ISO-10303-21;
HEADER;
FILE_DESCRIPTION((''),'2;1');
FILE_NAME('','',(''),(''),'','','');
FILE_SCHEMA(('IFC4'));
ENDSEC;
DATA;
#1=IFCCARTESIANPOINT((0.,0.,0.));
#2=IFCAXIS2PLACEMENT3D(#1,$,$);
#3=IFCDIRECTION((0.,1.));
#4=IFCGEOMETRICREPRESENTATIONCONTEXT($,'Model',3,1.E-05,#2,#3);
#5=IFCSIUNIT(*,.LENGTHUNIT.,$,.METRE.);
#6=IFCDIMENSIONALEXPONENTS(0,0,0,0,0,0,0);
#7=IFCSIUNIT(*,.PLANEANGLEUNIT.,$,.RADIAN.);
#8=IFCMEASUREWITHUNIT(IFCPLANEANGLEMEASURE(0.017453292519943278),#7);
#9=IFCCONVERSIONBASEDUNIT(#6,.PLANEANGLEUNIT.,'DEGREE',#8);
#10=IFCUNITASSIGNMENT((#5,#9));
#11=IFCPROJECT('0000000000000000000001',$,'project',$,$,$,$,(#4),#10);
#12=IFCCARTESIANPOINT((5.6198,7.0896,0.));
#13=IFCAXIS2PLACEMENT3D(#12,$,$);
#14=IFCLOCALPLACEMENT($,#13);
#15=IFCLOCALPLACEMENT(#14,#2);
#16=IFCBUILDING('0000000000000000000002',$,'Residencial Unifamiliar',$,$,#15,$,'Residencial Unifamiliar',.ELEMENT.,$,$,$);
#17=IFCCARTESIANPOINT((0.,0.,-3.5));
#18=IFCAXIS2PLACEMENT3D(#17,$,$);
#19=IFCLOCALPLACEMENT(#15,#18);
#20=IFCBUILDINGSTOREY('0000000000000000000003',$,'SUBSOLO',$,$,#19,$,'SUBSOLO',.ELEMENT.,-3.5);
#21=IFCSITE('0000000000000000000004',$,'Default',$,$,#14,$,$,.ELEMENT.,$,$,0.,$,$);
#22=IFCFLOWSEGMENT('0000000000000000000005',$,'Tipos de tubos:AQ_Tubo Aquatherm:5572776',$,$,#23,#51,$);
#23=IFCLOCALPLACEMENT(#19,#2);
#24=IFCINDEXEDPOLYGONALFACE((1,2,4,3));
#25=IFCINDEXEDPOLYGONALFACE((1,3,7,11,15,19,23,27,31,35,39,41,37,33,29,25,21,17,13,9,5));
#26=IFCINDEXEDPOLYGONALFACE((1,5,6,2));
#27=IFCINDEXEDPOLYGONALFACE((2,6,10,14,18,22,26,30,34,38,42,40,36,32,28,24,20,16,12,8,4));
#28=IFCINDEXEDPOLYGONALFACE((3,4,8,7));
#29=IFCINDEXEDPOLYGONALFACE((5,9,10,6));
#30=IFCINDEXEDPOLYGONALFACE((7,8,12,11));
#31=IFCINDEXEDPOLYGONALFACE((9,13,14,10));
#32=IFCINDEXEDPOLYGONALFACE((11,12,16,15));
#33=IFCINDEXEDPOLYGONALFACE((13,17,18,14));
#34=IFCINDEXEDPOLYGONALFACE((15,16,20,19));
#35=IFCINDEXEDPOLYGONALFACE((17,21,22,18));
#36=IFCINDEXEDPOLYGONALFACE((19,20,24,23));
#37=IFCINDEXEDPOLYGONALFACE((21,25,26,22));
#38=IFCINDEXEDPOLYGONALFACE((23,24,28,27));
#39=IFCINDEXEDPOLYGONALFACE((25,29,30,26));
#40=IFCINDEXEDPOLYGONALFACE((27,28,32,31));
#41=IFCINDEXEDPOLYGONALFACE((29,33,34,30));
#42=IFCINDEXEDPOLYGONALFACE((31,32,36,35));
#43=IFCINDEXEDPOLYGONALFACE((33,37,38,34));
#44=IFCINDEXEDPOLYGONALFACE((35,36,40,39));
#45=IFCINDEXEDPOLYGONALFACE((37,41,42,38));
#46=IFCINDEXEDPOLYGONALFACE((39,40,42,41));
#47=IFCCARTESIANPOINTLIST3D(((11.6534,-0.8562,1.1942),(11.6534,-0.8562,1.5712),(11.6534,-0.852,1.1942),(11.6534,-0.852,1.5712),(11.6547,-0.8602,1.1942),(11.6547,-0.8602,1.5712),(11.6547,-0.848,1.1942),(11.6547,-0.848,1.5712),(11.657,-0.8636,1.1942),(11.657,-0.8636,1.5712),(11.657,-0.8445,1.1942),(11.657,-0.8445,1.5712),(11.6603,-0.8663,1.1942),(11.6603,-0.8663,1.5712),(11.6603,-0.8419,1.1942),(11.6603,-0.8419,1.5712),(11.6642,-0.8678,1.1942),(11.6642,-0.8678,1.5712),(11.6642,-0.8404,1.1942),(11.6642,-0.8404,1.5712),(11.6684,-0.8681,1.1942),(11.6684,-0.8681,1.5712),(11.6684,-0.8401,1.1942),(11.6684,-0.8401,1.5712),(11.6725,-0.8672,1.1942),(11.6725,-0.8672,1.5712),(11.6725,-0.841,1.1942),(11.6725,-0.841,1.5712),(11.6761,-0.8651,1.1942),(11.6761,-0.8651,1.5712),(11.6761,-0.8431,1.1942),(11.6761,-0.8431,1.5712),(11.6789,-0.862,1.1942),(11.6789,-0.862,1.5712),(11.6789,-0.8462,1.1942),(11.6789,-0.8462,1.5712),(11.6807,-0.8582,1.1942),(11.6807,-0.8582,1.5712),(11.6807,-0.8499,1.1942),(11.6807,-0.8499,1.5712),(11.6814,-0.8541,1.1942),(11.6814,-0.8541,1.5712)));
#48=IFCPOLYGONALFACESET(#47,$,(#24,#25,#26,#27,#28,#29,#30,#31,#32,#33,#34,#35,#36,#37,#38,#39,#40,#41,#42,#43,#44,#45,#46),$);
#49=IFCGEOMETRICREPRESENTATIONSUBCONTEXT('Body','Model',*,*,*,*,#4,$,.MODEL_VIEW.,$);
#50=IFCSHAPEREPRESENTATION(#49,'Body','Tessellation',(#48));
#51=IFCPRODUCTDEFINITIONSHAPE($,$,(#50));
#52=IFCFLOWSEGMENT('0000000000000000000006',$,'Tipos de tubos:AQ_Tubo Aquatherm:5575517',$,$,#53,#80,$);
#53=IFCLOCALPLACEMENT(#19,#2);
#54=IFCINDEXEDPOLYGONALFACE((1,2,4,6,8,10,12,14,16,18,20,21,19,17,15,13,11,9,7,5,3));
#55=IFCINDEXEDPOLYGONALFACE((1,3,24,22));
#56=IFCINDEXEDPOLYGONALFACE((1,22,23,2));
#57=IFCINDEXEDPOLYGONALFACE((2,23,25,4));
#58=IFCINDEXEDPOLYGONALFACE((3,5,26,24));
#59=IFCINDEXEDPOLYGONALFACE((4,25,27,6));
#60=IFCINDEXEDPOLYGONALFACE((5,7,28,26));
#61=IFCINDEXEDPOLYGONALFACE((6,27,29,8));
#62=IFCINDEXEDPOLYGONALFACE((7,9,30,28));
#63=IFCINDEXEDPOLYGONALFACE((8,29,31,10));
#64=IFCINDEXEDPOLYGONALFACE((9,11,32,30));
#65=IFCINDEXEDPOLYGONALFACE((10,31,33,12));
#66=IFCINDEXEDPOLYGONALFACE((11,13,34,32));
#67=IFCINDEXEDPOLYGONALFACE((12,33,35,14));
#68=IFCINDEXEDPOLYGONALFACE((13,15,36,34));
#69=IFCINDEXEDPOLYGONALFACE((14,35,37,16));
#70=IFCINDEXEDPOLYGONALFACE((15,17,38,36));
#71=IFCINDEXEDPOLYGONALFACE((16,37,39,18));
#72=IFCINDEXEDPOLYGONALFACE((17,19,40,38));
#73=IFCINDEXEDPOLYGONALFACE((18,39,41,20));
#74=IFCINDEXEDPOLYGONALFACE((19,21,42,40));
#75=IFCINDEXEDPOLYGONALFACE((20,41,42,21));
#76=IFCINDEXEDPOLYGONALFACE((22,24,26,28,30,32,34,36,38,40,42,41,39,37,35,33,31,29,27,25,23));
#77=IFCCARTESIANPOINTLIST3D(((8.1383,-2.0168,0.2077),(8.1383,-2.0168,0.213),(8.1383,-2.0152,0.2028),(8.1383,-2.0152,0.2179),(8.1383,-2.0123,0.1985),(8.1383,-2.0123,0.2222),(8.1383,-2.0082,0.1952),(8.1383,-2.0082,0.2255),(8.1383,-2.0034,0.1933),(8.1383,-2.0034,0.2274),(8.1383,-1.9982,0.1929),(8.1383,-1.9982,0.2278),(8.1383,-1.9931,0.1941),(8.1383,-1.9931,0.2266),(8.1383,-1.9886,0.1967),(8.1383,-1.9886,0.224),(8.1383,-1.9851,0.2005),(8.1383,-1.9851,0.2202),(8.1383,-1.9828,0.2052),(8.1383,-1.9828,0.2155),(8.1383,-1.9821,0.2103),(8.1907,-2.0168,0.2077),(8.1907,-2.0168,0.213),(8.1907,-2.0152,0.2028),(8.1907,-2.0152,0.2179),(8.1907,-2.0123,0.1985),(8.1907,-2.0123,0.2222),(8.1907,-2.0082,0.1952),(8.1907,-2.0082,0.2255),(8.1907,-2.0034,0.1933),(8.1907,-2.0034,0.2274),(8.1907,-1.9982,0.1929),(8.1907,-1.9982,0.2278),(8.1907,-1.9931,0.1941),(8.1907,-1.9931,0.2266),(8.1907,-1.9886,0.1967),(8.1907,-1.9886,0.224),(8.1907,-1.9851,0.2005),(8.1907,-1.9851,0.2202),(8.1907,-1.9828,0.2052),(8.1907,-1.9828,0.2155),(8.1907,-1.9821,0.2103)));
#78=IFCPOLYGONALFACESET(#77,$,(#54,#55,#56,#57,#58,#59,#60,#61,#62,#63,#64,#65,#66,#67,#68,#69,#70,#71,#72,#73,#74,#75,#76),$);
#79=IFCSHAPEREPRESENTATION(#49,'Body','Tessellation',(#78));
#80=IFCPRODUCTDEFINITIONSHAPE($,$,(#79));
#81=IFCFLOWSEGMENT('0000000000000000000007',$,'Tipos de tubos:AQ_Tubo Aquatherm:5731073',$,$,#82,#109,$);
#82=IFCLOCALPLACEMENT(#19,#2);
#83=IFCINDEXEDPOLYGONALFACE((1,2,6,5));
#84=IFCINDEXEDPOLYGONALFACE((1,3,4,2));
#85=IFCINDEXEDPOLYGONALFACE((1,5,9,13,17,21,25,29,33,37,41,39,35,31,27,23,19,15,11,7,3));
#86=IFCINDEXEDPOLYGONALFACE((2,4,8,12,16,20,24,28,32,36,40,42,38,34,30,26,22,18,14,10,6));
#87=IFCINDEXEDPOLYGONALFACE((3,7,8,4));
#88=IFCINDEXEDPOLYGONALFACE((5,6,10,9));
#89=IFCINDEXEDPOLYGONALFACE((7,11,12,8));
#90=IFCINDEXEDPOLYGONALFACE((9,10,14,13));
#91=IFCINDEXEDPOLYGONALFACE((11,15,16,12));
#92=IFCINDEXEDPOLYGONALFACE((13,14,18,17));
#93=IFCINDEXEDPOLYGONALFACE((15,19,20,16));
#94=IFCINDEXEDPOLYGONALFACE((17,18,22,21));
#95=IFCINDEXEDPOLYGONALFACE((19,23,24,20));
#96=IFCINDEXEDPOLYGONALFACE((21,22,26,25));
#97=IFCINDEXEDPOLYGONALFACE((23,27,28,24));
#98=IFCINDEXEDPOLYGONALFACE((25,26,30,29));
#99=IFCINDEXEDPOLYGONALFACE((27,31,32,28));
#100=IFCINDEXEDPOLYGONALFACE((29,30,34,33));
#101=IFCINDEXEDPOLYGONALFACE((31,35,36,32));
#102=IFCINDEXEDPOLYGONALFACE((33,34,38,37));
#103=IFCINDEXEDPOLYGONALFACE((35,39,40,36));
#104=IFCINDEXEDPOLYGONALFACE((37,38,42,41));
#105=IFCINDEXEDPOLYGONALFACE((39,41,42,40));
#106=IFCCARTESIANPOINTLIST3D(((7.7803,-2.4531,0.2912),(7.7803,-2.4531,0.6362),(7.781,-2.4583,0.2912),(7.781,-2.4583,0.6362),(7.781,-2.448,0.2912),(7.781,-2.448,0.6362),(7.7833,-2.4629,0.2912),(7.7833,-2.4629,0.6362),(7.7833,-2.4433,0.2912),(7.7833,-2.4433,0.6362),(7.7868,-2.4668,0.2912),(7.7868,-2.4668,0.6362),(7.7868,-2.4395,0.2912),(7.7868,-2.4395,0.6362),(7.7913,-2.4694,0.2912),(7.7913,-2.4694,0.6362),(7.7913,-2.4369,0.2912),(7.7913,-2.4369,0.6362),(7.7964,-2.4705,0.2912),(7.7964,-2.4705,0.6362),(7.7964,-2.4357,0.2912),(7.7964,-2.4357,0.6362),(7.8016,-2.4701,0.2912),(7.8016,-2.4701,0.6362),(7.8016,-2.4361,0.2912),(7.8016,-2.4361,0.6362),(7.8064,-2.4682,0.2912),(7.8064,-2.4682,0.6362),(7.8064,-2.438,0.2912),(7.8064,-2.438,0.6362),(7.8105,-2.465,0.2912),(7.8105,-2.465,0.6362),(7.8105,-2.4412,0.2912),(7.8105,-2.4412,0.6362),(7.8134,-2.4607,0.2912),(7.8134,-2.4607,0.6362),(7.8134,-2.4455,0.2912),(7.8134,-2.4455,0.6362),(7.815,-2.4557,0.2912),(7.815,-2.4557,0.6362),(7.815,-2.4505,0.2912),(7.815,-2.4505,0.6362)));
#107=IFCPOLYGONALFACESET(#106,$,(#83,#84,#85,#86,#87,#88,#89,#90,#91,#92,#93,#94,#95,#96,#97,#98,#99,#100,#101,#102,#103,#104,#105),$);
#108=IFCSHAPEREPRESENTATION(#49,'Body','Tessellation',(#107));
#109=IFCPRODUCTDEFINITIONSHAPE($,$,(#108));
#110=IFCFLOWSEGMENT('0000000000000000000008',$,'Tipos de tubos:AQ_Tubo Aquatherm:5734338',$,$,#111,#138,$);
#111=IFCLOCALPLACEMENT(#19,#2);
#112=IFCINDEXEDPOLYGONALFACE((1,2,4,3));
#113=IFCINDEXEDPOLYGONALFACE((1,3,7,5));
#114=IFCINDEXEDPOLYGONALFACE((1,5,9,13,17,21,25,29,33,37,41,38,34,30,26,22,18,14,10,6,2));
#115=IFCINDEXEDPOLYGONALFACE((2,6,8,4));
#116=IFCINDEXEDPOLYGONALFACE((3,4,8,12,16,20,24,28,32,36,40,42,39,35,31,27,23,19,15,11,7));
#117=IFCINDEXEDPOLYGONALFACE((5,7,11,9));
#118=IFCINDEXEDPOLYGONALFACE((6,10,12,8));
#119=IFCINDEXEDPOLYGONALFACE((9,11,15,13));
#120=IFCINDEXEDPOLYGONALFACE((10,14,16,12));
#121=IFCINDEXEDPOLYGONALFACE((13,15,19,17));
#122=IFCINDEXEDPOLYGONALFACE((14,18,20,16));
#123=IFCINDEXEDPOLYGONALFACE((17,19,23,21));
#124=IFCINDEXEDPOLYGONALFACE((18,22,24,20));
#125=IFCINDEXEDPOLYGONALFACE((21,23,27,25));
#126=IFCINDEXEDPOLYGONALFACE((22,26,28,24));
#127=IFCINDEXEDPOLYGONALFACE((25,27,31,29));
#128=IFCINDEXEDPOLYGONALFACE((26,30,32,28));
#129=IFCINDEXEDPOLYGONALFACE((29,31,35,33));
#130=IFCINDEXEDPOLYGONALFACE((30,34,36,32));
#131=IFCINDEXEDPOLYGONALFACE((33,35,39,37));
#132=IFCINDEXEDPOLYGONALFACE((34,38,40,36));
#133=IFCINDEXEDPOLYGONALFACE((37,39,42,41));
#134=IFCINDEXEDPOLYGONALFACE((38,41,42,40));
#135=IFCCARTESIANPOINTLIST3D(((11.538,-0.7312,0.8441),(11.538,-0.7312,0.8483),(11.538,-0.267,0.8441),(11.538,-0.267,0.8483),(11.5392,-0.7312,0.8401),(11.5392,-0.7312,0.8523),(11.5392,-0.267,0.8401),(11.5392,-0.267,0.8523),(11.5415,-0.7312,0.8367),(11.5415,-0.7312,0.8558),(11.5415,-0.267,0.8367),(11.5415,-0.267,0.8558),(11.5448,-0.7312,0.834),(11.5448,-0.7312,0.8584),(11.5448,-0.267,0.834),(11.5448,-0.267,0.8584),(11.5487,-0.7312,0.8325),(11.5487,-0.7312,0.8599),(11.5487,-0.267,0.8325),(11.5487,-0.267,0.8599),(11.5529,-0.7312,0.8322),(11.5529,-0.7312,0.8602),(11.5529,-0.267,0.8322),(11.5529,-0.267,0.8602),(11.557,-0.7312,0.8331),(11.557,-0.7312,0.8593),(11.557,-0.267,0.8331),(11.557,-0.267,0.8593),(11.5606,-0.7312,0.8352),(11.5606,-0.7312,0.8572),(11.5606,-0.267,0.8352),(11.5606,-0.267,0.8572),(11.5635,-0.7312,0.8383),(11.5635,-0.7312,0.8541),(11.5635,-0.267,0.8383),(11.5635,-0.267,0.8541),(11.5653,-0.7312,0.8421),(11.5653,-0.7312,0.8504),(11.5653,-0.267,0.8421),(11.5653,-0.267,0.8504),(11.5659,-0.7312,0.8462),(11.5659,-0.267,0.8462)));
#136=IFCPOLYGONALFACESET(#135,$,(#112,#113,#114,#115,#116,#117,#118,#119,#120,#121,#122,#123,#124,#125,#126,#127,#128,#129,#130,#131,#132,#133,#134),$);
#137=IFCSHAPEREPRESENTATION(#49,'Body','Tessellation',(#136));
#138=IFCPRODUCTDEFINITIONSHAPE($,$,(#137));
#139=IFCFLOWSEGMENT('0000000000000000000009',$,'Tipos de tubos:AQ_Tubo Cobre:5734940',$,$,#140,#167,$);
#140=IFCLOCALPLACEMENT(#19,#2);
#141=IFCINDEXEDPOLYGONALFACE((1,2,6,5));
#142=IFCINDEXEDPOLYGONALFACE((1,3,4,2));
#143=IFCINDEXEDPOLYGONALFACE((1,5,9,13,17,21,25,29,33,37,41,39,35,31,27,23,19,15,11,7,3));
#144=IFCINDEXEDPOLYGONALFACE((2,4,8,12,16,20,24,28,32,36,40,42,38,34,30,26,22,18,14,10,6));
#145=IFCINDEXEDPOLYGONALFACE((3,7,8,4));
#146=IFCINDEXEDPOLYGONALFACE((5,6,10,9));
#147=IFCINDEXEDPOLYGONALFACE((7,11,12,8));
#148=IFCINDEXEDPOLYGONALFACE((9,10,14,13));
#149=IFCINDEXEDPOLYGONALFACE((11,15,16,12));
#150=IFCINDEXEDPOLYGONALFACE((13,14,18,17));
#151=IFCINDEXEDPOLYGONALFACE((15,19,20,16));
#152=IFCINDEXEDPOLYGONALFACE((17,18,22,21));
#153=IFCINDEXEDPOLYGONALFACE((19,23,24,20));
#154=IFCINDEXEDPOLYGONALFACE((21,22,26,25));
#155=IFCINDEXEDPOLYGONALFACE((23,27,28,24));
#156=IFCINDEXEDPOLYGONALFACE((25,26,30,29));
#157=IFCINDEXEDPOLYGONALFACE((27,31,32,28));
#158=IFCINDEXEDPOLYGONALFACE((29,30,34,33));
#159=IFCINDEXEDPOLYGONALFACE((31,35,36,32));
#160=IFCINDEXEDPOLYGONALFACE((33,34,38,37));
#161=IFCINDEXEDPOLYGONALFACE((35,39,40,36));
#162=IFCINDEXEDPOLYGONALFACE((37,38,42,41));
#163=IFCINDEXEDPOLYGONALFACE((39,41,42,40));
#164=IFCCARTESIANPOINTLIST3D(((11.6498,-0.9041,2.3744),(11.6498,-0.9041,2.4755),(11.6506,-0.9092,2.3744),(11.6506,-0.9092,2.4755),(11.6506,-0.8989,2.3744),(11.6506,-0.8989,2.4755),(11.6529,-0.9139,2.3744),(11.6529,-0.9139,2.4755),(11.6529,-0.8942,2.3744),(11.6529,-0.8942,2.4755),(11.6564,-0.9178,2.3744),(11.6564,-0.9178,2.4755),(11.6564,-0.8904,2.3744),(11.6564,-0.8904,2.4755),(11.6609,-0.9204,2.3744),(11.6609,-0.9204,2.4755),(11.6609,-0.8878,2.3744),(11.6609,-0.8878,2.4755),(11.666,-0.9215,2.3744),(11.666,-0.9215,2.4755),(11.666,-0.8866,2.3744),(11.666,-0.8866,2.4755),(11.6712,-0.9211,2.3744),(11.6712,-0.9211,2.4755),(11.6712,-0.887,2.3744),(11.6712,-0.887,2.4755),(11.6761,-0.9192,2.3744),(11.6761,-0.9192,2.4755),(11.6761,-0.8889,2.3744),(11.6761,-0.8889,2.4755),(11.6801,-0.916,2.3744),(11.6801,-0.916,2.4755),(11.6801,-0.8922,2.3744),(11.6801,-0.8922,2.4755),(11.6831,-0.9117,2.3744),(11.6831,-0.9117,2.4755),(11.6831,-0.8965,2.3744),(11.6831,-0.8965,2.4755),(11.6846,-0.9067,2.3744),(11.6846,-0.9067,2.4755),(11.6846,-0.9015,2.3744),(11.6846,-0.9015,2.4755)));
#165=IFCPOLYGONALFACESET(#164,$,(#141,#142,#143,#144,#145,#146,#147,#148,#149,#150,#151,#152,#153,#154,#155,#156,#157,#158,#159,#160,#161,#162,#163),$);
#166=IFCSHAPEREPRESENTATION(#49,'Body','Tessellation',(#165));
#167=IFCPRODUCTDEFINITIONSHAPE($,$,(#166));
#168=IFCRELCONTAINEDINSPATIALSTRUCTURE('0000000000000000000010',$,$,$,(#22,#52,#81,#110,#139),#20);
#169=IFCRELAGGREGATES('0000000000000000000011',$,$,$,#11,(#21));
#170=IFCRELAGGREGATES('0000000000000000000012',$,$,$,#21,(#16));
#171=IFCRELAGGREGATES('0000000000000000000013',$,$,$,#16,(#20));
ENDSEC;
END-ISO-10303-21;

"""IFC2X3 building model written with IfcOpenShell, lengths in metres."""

from ifc_helpers import new_model, entity, si_unit, converted_unit, direction, frame, origin, origin_2d_with_axis, place, context, subcontext, project, spatial, circle, extrude, element, save


model = new_model("IFC2X3")

# Units and contexts
model_context = context("Model", 3, precision=1e-05, world=origin(), true_north=direction((0.0, 1.0)))
body_context = subcontext(model_context, "Body", "Model", "MODEL_VIEW")
ifc_project = project(units=[si_unit("LENGTHUNIT", "METRE"), converted_unit("PLANEANGLEUNIT", "DEGREE", entity("IfcPlaneAngleMeasure", 0.017453292519943278), si_unit("PLANEANGLEUNIT", "RADIAN"), dimensions=[0, 0, 0, 0, 0, 0, 0])], contexts=[model_context])

# Site, building, storey
site_placement = place(None, frame((5.6198, 7.0896, 0.0)))
site = spatial("IfcSite", under=ifc_project, at=site_placement, Name="Default", CompositionType="ELEMENT", RefElevation=0.0)
building_placement = place(site_placement, origin())
building = spatial("IfcBuilding", under=site, at=building_placement, Name="Residencial Unifamiliar", LongName="Residencial Unifamiliar", CompositionType="ELEMENT")
storey_placement = place(building_placement, frame((0.0, 0.0, -3.5)))
storey = spatial("IfcBuildingStorey", under=building, at=storey_placement, Name="SUBSOLO", LongName="SUBSOLO", CompositionType="ELEMENT", Elevation=-3.5)

# Flow segments
flow_segment_1_placement = place(storey_placement, origin())
element("IfcFlowSegment", 1, at=flow_segment_1_placement, inside=storey, Name="Tipos de tubos:AQ_Tubo Aquatherm:5572776", context=body_context, shape_type="SweptSolid", body=[
    extrude(circle(Radius=0.0141, at=origin_2d_with_axis()), frame((11.6673, -0.8541, 1.1942)), (0.0, 0.0, 1.0), 0.3769),
])
flow_segment_2_placement = place(storey_placement, origin())
element("IfcFlowSegment", 2, at=flow_segment_2_placement, inside=storey, Name="Tipos de tubos:AQ_Tubo Aquatherm:5575517", context=body_context, shape_type="SweptSolid", body=[
    extrude(circle(Radius=0.0175, at=origin_2d_with_axis()), frame((8.1383, -1.9995, 0.2103), z_axis=(1.0, 0.0, 0.0), x_axis=(0.0, 1.0, 0.0)), (0.0, 0.0, 1.0), 0.0524),
])
flow_segment_3_placement = place(storey_placement, origin())
element("IfcFlowSegment", 3, at=flow_segment_3_placement, inside=storey, Name="Tipos de tubos:AQ_Tubo Aquatherm:5731073", context=body_context, shape_type="SweptSolid", body=[
    extrude(circle(Radius=0.0175, at=origin_2d_with_axis()), frame((7.7977, -2.4531, 0.2912), z_axis=(0.0, 0.0, 1.0), x_axis=(-1.0, 0.0, 0.0)), (0.0, 0.0, 1.0), 0.345),
])
flow_segment_4_placement = place(storey_placement, origin())
element("IfcFlowSegment", 4, at=flow_segment_4_placement, inside=storey, Name="Tipos de tubos:AQ_Tubo Aquatherm:5734338", context=body_context, shape_type="SweptSolid", body=[
    extrude(circle(Radius=0.0141, at=origin_2d_with_axis()), frame((11.5518, -0.7312, 0.8462), z_axis=(0.0, 1.0, 0.0), x_axis=(1.0, 0.0, 0.0)), (0.0, 0.0, 1.0), 0.4642),
])
flow_segment_5_placement = place(storey_placement, origin())
element("IfcFlowSegment", 5, at=flow_segment_5_placement, inside=storey, Name="Tipos de tubos:AQ_Tubo Cobre:5734940", context=body_context, shape_type="SweptSolid", body=[
    extrude(circle(Radius=0.0175, at=origin_2d_with_axis()), frame((11.6673, -0.9041, 2.3744), z_axis=(0.0, 0.0, 1.0), x_axis=(-1.0, 0.0, 0.0)), (0.0, 0.0, 1.0), 0.1011),
])

save(model, "model.ifc")
